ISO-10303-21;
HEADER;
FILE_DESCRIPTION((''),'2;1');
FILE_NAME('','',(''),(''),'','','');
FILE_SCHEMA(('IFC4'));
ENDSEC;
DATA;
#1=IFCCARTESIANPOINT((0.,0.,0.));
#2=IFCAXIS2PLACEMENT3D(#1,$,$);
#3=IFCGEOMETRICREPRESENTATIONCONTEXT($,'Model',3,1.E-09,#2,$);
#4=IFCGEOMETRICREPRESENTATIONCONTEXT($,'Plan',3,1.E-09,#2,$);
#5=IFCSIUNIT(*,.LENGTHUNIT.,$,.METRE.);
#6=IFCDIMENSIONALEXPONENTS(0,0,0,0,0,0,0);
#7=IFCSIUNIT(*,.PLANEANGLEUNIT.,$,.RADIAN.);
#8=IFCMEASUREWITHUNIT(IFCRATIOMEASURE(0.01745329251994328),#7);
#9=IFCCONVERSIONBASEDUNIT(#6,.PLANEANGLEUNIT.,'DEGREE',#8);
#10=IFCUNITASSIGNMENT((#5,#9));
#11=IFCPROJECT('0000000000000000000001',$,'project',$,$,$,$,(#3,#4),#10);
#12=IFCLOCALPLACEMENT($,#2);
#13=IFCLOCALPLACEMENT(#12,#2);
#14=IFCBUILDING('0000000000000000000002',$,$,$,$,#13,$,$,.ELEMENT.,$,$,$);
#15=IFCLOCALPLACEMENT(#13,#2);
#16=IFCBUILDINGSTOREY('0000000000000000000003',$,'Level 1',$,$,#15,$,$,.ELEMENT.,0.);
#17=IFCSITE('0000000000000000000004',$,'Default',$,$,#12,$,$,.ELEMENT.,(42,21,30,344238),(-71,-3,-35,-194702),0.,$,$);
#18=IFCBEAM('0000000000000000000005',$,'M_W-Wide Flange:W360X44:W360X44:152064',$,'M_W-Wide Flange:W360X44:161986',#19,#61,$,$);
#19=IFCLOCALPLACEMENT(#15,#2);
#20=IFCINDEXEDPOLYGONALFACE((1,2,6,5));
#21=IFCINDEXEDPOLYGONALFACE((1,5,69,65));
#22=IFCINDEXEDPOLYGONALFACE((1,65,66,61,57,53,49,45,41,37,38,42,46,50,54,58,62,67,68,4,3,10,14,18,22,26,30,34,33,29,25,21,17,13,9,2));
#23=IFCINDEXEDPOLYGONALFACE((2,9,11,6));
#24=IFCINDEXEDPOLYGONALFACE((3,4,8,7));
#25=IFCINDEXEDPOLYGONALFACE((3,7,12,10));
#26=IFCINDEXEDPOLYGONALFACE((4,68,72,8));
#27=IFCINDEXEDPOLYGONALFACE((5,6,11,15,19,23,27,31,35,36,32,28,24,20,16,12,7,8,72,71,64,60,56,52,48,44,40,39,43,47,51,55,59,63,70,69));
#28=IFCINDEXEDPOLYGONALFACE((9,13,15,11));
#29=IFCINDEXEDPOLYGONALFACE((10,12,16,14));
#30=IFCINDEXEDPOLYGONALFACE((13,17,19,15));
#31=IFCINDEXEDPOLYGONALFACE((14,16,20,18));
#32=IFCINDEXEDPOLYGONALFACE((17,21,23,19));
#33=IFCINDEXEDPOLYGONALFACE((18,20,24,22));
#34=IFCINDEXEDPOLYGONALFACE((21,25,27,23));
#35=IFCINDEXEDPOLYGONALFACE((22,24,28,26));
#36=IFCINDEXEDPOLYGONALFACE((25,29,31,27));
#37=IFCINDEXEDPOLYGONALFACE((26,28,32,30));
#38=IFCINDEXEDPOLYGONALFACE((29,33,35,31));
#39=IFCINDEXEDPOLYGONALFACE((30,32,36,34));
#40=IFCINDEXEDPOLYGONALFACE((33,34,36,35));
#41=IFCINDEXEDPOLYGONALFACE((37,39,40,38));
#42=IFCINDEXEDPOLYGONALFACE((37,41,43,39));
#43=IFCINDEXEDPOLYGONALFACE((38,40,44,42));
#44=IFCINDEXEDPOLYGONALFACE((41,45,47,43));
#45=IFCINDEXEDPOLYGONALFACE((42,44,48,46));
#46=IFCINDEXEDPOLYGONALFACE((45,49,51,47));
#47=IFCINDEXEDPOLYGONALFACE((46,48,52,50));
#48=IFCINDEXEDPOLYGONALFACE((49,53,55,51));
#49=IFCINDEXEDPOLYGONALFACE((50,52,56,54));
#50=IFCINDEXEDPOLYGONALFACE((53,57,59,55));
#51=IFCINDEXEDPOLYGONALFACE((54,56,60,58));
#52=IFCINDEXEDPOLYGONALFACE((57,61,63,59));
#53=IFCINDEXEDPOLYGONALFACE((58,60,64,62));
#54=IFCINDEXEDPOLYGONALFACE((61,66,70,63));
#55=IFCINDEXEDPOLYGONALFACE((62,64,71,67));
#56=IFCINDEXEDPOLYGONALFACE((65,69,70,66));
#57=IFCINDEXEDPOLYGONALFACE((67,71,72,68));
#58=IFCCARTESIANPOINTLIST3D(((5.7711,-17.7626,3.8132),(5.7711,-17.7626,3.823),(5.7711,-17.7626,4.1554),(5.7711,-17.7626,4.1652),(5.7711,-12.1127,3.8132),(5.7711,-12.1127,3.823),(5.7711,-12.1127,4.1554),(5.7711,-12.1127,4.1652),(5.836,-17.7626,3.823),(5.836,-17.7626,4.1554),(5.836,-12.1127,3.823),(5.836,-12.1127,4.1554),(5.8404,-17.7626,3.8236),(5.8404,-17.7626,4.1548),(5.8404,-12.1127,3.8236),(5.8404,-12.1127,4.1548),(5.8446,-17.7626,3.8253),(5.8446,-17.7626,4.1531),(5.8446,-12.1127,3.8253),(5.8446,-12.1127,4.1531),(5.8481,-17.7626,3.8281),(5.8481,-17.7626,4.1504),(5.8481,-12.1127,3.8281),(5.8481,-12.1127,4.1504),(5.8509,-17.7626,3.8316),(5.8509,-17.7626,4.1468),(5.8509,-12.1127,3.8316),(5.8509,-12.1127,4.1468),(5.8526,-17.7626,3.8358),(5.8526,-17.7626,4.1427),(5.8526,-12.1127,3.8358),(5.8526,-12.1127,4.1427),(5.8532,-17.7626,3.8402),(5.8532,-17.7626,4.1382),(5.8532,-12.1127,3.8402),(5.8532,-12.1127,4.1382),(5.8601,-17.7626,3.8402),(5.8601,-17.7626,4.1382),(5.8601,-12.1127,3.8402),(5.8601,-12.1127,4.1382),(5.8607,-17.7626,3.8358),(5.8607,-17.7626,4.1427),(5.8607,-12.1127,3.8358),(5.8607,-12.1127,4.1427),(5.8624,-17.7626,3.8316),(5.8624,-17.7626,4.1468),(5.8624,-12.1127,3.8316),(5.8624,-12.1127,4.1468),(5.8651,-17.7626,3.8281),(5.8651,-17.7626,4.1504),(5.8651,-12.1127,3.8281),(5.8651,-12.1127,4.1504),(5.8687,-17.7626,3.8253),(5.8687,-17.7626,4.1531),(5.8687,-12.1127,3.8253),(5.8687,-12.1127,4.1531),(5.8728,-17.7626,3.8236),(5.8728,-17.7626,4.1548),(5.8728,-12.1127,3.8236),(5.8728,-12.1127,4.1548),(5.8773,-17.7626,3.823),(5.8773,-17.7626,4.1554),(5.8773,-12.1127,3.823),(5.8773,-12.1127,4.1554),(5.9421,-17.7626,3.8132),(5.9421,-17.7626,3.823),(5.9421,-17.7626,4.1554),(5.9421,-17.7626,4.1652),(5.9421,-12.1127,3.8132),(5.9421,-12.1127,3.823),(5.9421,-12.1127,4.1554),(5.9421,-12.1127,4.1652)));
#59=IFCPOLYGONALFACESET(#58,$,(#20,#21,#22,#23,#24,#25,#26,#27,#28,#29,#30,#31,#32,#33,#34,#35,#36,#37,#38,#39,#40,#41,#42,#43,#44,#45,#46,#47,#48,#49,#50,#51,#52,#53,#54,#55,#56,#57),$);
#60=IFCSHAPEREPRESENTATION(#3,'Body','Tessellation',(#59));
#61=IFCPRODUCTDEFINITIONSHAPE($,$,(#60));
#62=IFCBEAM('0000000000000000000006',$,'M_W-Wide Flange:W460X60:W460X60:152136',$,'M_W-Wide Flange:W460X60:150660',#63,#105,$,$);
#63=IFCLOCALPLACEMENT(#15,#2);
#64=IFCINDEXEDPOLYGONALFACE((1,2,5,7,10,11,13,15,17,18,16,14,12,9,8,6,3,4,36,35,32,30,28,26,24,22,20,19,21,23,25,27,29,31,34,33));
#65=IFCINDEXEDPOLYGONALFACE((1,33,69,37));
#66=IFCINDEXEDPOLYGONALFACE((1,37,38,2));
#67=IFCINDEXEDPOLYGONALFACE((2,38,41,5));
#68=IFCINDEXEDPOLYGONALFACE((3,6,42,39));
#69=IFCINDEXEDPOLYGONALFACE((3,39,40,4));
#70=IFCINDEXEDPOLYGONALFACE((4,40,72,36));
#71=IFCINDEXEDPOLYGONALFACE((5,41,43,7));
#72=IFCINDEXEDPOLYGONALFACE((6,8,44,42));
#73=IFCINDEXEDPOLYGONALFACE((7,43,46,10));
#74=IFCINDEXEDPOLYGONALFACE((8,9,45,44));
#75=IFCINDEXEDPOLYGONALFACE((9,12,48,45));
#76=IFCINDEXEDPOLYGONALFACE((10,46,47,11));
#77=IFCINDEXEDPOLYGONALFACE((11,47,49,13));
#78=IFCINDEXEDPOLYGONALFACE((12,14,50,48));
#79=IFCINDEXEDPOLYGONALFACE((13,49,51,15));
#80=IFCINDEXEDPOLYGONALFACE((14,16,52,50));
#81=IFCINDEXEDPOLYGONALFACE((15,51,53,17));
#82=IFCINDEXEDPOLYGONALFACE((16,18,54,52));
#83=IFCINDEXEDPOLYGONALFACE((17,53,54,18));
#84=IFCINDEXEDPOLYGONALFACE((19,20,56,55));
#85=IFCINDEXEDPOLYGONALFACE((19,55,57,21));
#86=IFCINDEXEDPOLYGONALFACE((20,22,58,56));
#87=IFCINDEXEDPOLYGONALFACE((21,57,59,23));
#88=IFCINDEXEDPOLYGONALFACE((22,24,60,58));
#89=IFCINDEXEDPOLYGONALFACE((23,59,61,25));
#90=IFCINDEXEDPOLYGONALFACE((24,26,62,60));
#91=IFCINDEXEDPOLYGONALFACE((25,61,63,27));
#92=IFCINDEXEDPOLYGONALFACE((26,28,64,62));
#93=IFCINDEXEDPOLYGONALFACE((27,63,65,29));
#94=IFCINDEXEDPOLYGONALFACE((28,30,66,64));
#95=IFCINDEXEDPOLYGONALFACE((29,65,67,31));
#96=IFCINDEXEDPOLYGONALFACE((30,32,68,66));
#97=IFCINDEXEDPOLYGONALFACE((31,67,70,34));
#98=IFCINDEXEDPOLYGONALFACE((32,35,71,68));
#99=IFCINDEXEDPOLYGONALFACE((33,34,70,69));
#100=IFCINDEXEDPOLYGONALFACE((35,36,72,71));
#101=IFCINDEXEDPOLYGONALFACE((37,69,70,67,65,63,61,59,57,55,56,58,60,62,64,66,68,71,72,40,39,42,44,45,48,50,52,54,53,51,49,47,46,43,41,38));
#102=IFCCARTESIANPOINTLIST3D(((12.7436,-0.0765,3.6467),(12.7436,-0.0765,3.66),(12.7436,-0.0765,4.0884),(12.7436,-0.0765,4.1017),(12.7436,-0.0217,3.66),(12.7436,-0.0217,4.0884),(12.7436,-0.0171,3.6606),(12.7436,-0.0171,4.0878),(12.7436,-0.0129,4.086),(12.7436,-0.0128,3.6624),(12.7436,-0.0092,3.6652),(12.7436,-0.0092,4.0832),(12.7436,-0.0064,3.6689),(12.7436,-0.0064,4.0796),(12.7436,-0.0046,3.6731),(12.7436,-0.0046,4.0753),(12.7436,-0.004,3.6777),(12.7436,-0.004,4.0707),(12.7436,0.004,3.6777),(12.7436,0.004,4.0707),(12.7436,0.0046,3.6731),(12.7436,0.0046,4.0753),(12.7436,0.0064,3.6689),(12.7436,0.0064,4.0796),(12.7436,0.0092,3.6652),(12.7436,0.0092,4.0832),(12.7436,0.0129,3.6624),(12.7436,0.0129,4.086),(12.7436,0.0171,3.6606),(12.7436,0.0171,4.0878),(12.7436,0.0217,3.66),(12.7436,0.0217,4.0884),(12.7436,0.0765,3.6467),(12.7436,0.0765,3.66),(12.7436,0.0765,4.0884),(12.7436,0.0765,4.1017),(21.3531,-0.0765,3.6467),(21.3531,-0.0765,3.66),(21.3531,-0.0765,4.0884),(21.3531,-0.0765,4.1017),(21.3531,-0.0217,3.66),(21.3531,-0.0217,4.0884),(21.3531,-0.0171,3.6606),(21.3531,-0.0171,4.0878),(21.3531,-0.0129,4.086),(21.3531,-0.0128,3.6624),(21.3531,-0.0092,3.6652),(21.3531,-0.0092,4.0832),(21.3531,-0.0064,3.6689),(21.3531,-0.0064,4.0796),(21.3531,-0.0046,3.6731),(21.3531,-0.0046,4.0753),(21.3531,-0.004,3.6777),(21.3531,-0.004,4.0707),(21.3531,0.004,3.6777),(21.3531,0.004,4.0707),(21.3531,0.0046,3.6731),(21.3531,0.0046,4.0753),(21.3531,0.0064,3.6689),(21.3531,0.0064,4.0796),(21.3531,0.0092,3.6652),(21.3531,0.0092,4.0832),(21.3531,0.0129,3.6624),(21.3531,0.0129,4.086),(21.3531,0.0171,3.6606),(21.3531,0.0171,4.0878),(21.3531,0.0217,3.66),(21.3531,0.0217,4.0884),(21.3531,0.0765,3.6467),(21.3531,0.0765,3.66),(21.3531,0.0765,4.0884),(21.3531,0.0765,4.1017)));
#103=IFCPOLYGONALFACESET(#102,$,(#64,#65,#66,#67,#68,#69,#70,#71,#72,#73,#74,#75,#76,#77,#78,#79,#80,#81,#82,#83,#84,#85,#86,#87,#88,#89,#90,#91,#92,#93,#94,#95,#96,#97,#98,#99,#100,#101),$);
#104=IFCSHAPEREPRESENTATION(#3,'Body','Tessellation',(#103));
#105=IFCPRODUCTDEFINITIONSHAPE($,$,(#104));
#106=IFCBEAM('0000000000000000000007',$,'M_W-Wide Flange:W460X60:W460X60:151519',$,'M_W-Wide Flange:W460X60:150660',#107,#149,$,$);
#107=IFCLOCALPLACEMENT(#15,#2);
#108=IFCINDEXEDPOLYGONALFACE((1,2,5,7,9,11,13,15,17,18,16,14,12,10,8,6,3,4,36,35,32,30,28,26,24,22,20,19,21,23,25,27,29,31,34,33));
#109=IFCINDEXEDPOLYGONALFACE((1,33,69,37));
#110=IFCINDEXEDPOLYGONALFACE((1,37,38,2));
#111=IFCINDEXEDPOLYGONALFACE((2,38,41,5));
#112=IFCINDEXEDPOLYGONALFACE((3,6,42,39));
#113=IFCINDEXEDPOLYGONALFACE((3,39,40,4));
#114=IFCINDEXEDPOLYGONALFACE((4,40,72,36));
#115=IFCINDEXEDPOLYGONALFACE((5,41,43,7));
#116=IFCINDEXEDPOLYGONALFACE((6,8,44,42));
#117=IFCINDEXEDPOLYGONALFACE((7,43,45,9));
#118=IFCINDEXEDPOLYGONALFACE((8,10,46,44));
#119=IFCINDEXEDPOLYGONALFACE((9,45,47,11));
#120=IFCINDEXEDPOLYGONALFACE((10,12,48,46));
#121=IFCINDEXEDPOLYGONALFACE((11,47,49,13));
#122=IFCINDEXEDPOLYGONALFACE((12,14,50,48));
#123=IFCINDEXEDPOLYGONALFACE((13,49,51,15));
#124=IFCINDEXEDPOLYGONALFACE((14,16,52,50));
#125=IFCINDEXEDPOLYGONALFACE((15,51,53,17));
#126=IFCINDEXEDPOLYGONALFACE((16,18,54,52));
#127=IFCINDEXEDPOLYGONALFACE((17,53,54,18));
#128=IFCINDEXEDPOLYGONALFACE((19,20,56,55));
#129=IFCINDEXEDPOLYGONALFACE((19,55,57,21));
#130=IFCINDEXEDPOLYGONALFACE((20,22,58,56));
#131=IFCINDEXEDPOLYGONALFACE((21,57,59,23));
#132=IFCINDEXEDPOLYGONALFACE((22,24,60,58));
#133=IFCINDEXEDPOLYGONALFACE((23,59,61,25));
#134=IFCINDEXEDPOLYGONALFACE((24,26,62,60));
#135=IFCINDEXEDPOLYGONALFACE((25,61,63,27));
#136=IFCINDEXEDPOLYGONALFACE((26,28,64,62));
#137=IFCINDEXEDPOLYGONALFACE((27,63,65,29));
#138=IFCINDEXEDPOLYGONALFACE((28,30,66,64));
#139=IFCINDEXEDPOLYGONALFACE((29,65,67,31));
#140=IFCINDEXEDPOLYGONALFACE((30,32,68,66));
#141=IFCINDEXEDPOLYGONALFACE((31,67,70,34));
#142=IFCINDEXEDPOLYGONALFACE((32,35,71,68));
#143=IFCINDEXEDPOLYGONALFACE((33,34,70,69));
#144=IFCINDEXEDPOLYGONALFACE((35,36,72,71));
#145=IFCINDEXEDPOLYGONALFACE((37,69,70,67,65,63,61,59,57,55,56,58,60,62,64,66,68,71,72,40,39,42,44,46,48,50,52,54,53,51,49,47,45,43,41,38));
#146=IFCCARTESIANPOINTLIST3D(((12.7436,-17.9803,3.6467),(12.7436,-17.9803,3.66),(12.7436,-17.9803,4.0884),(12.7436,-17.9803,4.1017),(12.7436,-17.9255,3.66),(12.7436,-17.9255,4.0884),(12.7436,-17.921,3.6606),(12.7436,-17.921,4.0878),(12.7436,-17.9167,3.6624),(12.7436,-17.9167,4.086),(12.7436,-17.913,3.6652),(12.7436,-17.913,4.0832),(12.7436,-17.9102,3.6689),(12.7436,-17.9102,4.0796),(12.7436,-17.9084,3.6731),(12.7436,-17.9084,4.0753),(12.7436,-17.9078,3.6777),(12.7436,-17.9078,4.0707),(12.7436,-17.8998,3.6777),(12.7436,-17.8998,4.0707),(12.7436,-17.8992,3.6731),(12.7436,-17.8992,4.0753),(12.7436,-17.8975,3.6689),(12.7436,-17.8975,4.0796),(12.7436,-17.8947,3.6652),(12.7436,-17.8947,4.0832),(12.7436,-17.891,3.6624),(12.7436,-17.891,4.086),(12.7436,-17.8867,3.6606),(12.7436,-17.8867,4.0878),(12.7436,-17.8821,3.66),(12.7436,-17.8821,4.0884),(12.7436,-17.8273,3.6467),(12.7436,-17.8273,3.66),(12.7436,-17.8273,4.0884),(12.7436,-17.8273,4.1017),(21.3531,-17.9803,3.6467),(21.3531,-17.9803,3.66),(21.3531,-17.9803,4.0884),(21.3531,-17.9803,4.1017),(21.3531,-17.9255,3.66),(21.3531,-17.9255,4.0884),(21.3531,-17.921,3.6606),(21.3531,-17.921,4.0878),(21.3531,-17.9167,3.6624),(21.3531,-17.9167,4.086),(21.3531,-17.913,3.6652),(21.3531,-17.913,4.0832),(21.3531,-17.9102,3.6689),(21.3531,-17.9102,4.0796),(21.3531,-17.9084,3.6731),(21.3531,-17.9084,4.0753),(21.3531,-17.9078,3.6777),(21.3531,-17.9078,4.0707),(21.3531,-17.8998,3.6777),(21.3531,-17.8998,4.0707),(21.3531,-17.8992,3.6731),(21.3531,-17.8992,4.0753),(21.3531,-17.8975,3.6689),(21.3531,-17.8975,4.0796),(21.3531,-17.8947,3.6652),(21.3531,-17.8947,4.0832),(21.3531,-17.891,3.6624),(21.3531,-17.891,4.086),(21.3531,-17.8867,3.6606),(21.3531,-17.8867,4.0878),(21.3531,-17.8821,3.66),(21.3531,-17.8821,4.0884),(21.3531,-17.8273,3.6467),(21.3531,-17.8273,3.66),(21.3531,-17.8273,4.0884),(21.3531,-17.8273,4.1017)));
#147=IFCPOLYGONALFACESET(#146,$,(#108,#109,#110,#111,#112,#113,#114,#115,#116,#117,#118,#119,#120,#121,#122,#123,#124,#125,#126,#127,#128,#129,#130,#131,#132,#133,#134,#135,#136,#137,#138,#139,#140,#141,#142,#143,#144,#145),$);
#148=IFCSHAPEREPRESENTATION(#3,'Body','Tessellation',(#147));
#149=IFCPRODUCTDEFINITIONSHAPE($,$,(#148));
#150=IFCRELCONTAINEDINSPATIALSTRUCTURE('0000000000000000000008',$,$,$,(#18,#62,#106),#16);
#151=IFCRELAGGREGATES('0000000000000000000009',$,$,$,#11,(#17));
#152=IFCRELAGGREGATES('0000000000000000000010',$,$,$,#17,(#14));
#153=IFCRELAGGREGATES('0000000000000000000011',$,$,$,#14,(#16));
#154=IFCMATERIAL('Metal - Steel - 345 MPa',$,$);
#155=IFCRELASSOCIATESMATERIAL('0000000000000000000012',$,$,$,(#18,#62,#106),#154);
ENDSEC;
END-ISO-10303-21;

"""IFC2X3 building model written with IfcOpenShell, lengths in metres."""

from ifc_helpers import new_model, entity, si_unit, converted_unit, frame, frame_2d, origin, place, context, project, spatial, polyline, circle_curve, parameter, trimmed, segment, composite_curve, outline, extrude, material, element, save


model = new_model("IFC2X3")

# Units and contexts
model_context = context("Model", 3, precision=1e-09, world=origin())
plan_context = context("Plan", 3, precision=1e-09, world=origin())
ifc_project = project(units=[si_unit("LENGTHUNIT", "METRE"), converted_unit("PLANEANGLEUNIT", "DEGREE", entity("IfcRatioMeasure", 0.01745329251994328), si_unit("PLANEANGLEUNIT", "RADIAN"), dimensions=[0, 0, 0, 0, 0, 0, 0])], contexts=[model_context, plan_context])

# Site, building, storey
site_placement = place(None, origin())
site = spatial("IfcSite", under=ifc_project, at=site_placement, Name="Default", CompositionType="ELEMENT", RefLatitude=(42, 21, 30, 344238), RefLongitude=(-71, -3, -35, -194702), RefElevation=0.0)
building_placement = place(site_placement, origin())
building = spatial("IfcBuilding", under=site, at=building_placement, CompositionType="ELEMENT")
storey_placement = place(building_placement, origin())
storey = spatial("IfcBuildingStorey", under=building, at=storey_placement, Name="Level 1", CompositionType="ELEMENT", Elevation=0.0)

# Beams
ifc_material_1 = material(Name="Metal - Steel - 345 MPa")
beam_1_placement = place(storey_placement, frame((5.8566, -17.9038, 4.2672)))
element("IfcBeam", 1, at=beam_1_placement, inside=storey, material=ifc_material_1, Name="M_W-Wide Flange:W360X44:W360X44:152064", ObjectType="M_W-Wide Flange:W360X44:161986", context=model_context, shape_type="SweptSolid", body=[
    extrude(outline(composite_curve([segment(polyline([(-0.0855, -0.1662), (-0.0855, -0.176)]), True, "CONTINUOUS"), segment(polyline([(-0.0855, -0.176), (0.0855, -0.176)]), True, "CONTINUOUS"), segment(polyline([(0.0855, -0.176), (0.0855, -0.1662)]), True, "CONTINUOUS"), segment(polyline([(0.0855, -0.1662), (0.0206, -0.1662)]), True, "CONTINUOUS"), segment(trimmed(circle_curve(frame_2d((0.0206, -0.149), x_axis=(1.0, 0.0)), 0.0172), [parameter(180.0)], [parameter(270.0)], True, "PARAMETER"), False, "CONTINUOUS"), segment(polyline([(0.0034, -0.149), (0.0034, 0.149)]), True, "CONTINUOUS"), segment(trimmed(circle_curve(frame_2d((0.0206, 0.149), x_axis=(1.0, 0.0)), 0.0172), [parameter(90.0)], [parameter(180.0)], True, "PARAMETER"), False, "CONTINUOUS"), segment(polyline([(0.0206, 0.1662), (0.0855, 0.1662)]), True, "CONTINUOUS"), segment(polyline([(0.0855, 0.1662), (0.0855, 0.176)]), True, "CONTINUOUS"), segment(polyline([(0.0855, 0.176), (-0.0855, 0.176)]), True, "CONTINUOUS"), segment(polyline([(-0.0855, 0.176), (-0.0855, 0.1662)]), True, "CONTINUOUS"), segment(polyline([(-0.0855, 0.1662), (-0.0207, 0.1662)]), True, "CONTINUOUS"), segment(trimmed(circle_curve(frame_2d((-0.0207, 0.149), x_axis=(1.0, 0.0)), 0.0172), [parameter(360.0)], [parameter(90.0)], True, "PARAMETER"), False, "CONTINUOUS"), segment(polyline([(-0.0035, 0.149), (-0.0035, -0.149)]), True, "CONTINUOUS"), segment(trimmed(circle_curve(frame_2d((-0.0207, -0.149), x_axis=(1.0, 0.0)), 0.0172), [parameter(270.0)], [parameter(0.0)], True, "PARAMETER"), False, "CONTINUOUS"), segment(polyline([(-0.0207, -0.1662), (-0.0855, -0.1662)]), True, "CONTINUOUS")], self_intersect=False)), frame((0.0, 0.1412, -0.278), z_axis=(0.0, -1.0, 0.0), x_axis=(1.0, 0.0, 0.0)), (0.0, 0.0, -1.0), 5.65),
])
beam_2_placement = place(storey_placement, frame((12.6289, 0.0, 4.2672), z_axis=(0.0, 0.0, 1.0), x_axis=(0.0, -1.0, 0.0)))
element("IfcBeam", 2, at=beam_2_placement, inside=storey, material=ifc_material_1, Name="M_W-Wide Flange:W460X60:W460X60:152136", ObjectType="M_W-Wide Flange:W460X60:150660", context=model_context, shape_type="SweptSolid", body=[
    extrude(outline(composite_curve([segment(polyline([(-0.0765, -0.2142), (-0.0765, -0.2275)]), True, "CONTINUOUS"), segment(polyline([(-0.0765, -0.2275), (0.0765, -0.2275)]), True, "CONTINUOUS"), segment(polyline([(0.0765, -0.2275), (0.0765, -0.2142)]), True, "CONTINUOUS"), segment(polyline([(0.0765, -0.2142), (0.0217, -0.2142)]), True, "CONTINUOUS"), segment(trimmed(circle_curve(frame_2d((0.0217, -0.1965), x_axis=(0.0, -1.0)), 0.0177), [parameter(270.0)], [parameter(360.0)], True, "PARAMETER"), False, "CONTINUOUS"), segment(polyline([(0.004, -0.1965), (0.004, 0.1965)]), True, "CONTINUOUS"), segment(trimmed(circle_curve(frame_2d((0.0217, 0.1965), x_axis=(-1.0, 0.0)), 0.0177), [parameter(270.0)], [parameter(360.0)], True, "PARAMETER"), False, "CONTINUOUS"), segment(polyline([(0.0217, 0.2142), (0.0765, 0.2142)]), True, "CONTINUOUS"), segment(polyline([(0.0765, 0.2142), (0.0765, 0.2275)]), True, "CONTINUOUS"), segment(polyline([(0.0765, 0.2275), (-0.0765, 0.2275)]), True, "CONTINUOUS"), segment(polyline([(-0.0765, 0.2275), (-0.0765, 0.2142)]), True, "CONTINUOUS"), segment(polyline([(-0.0765, 0.2142), (-0.0217, 0.2142)]), True, "CONTINUOUS"), segment(trimmed(circle_curve(frame_2d((-0.0217, 0.1965), x_axis=(0.0, 1.0)), 0.0177), [parameter(270.0)], [parameter(360.0)], True, "PARAMETER"), False, "CONTINUOUS"), segment(polyline([(-0.004, 0.1965), (-0.004, -0.1965)]), True, "CONTINUOUS"), segment(trimmed(circle_curve(frame_2d((-0.0217, -0.1965), x_axis=(1.0, 0.0)), 0.0177), [parameter(270.0)], [parameter(0.0)], True, "PARAMETER"), False, "CONTINUOUS"), segment(polyline([(-0.0217, -0.2142), (-0.0765, -0.2142)]), True, "CONTINUOUS")], self_intersect=False)), frame((0.0, 0.1147, -0.393), z_axis=(0.0, -1.0, 0.0), x_axis=(1.0, 0.0, 0.0)), (0.0, 0.0, -1.0), 8.6095),
])
beam_3_placement = place(storey_placement, frame((21.4678, -17.9038, 4.2672), z_axis=(0.0, 0.0, 1.0), x_axis=(0.0, 1.0, 0.0)))
element("IfcBeam", 3, at=beam_3_placement, inside=storey, material=ifc_material_1, Name="M_W-Wide Flange:W460X60:W460X60:151519", ObjectType="M_W-Wide Flange:W460X60:150660", context=model_context, shape_type="SweptSolid", body=[
    extrude(outline(composite_curve([segment(polyline([(0.2142, -0.0765), (0.2275, -0.0765)]), True, "CONTINUOUS"), segment(polyline([(0.2275, -0.0765), (0.2275, 0.0765)]), True, "CONTINUOUS"), segment(polyline([(0.2275, 0.0765), (0.2142, 0.0765)]), True, "CONTINUOUS"), segment(polyline([(0.2142, 0.0765), (0.2142, 0.0217)]), True, "CONTINUOUS"), segment(trimmed(circle_curve(frame_2d((0.1965, 0.0217), x_axis=(1.0, 0.0)), 0.0177), [parameter(270.0)], [parameter(360.0)], True, "PARAMETER"), False, "CONTINUOUS"), segment(polyline([(0.1965, 0.004), (-0.1965, 0.004)]), True, "CONTINUOUS"), segment(trimmed(circle_curve(frame_2d((-0.1965, 0.0217), x_axis=(0.0, -1.0)), 0.0177), [parameter(270.0)], [parameter(360.0)], True, "PARAMETER"), False, "CONTINUOUS"), segment(polyline([(-0.2142, 0.0217), (-0.2142, 0.0765)]), True, "CONTINUOUS"), segment(polyline([(-0.2142, 0.0765), (-0.2275, 0.0765)]), True, "CONTINUOUS"), segment(polyline([(-0.2275, 0.0765), (-0.2275, -0.0765)]), True, "CONTINUOUS"), segment(polyline([(-0.2275, -0.0765), (-0.2142, -0.0765)]), True, "CONTINUOUS"), segment(polyline([(-0.2142, -0.0765), (-0.2142, -0.0217)]), True, "CONTINUOUS"), segment(trimmed(circle_curve(frame_2d((-0.1965, -0.0217), x_axis=(-1.0, 0.0)), 0.0177), [parameter(270.0)], [parameter(360.0)], True, "PARAMETER"), False, "CONTINUOUS"), segment(polyline([(-0.1965, -0.004), (0.1965, -0.004)]), True, "CONTINUOUS"), segment(trimmed(circle_curve(frame_2d((0.1965, -0.0217), x_axis=(0.0, 1.0)), 0.0177), [parameter(270.0)], [parameter(0.0)], True, "PARAMETER"), False, "CONTINUOUS"), segment(polyline([(0.2142, -0.0217), (0.2142, -0.0765)]), True, "CONTINUOUS")], self_intersect=False)), frame((0.0, 8.7242, -0.393), z_axis=(0.0, -1.0, 0.0), x_axis=(0.0, 0.0, -1.0)), (0.0, 0.0, 1.0), 8.6095),
])

save(model, "model.ifc")
